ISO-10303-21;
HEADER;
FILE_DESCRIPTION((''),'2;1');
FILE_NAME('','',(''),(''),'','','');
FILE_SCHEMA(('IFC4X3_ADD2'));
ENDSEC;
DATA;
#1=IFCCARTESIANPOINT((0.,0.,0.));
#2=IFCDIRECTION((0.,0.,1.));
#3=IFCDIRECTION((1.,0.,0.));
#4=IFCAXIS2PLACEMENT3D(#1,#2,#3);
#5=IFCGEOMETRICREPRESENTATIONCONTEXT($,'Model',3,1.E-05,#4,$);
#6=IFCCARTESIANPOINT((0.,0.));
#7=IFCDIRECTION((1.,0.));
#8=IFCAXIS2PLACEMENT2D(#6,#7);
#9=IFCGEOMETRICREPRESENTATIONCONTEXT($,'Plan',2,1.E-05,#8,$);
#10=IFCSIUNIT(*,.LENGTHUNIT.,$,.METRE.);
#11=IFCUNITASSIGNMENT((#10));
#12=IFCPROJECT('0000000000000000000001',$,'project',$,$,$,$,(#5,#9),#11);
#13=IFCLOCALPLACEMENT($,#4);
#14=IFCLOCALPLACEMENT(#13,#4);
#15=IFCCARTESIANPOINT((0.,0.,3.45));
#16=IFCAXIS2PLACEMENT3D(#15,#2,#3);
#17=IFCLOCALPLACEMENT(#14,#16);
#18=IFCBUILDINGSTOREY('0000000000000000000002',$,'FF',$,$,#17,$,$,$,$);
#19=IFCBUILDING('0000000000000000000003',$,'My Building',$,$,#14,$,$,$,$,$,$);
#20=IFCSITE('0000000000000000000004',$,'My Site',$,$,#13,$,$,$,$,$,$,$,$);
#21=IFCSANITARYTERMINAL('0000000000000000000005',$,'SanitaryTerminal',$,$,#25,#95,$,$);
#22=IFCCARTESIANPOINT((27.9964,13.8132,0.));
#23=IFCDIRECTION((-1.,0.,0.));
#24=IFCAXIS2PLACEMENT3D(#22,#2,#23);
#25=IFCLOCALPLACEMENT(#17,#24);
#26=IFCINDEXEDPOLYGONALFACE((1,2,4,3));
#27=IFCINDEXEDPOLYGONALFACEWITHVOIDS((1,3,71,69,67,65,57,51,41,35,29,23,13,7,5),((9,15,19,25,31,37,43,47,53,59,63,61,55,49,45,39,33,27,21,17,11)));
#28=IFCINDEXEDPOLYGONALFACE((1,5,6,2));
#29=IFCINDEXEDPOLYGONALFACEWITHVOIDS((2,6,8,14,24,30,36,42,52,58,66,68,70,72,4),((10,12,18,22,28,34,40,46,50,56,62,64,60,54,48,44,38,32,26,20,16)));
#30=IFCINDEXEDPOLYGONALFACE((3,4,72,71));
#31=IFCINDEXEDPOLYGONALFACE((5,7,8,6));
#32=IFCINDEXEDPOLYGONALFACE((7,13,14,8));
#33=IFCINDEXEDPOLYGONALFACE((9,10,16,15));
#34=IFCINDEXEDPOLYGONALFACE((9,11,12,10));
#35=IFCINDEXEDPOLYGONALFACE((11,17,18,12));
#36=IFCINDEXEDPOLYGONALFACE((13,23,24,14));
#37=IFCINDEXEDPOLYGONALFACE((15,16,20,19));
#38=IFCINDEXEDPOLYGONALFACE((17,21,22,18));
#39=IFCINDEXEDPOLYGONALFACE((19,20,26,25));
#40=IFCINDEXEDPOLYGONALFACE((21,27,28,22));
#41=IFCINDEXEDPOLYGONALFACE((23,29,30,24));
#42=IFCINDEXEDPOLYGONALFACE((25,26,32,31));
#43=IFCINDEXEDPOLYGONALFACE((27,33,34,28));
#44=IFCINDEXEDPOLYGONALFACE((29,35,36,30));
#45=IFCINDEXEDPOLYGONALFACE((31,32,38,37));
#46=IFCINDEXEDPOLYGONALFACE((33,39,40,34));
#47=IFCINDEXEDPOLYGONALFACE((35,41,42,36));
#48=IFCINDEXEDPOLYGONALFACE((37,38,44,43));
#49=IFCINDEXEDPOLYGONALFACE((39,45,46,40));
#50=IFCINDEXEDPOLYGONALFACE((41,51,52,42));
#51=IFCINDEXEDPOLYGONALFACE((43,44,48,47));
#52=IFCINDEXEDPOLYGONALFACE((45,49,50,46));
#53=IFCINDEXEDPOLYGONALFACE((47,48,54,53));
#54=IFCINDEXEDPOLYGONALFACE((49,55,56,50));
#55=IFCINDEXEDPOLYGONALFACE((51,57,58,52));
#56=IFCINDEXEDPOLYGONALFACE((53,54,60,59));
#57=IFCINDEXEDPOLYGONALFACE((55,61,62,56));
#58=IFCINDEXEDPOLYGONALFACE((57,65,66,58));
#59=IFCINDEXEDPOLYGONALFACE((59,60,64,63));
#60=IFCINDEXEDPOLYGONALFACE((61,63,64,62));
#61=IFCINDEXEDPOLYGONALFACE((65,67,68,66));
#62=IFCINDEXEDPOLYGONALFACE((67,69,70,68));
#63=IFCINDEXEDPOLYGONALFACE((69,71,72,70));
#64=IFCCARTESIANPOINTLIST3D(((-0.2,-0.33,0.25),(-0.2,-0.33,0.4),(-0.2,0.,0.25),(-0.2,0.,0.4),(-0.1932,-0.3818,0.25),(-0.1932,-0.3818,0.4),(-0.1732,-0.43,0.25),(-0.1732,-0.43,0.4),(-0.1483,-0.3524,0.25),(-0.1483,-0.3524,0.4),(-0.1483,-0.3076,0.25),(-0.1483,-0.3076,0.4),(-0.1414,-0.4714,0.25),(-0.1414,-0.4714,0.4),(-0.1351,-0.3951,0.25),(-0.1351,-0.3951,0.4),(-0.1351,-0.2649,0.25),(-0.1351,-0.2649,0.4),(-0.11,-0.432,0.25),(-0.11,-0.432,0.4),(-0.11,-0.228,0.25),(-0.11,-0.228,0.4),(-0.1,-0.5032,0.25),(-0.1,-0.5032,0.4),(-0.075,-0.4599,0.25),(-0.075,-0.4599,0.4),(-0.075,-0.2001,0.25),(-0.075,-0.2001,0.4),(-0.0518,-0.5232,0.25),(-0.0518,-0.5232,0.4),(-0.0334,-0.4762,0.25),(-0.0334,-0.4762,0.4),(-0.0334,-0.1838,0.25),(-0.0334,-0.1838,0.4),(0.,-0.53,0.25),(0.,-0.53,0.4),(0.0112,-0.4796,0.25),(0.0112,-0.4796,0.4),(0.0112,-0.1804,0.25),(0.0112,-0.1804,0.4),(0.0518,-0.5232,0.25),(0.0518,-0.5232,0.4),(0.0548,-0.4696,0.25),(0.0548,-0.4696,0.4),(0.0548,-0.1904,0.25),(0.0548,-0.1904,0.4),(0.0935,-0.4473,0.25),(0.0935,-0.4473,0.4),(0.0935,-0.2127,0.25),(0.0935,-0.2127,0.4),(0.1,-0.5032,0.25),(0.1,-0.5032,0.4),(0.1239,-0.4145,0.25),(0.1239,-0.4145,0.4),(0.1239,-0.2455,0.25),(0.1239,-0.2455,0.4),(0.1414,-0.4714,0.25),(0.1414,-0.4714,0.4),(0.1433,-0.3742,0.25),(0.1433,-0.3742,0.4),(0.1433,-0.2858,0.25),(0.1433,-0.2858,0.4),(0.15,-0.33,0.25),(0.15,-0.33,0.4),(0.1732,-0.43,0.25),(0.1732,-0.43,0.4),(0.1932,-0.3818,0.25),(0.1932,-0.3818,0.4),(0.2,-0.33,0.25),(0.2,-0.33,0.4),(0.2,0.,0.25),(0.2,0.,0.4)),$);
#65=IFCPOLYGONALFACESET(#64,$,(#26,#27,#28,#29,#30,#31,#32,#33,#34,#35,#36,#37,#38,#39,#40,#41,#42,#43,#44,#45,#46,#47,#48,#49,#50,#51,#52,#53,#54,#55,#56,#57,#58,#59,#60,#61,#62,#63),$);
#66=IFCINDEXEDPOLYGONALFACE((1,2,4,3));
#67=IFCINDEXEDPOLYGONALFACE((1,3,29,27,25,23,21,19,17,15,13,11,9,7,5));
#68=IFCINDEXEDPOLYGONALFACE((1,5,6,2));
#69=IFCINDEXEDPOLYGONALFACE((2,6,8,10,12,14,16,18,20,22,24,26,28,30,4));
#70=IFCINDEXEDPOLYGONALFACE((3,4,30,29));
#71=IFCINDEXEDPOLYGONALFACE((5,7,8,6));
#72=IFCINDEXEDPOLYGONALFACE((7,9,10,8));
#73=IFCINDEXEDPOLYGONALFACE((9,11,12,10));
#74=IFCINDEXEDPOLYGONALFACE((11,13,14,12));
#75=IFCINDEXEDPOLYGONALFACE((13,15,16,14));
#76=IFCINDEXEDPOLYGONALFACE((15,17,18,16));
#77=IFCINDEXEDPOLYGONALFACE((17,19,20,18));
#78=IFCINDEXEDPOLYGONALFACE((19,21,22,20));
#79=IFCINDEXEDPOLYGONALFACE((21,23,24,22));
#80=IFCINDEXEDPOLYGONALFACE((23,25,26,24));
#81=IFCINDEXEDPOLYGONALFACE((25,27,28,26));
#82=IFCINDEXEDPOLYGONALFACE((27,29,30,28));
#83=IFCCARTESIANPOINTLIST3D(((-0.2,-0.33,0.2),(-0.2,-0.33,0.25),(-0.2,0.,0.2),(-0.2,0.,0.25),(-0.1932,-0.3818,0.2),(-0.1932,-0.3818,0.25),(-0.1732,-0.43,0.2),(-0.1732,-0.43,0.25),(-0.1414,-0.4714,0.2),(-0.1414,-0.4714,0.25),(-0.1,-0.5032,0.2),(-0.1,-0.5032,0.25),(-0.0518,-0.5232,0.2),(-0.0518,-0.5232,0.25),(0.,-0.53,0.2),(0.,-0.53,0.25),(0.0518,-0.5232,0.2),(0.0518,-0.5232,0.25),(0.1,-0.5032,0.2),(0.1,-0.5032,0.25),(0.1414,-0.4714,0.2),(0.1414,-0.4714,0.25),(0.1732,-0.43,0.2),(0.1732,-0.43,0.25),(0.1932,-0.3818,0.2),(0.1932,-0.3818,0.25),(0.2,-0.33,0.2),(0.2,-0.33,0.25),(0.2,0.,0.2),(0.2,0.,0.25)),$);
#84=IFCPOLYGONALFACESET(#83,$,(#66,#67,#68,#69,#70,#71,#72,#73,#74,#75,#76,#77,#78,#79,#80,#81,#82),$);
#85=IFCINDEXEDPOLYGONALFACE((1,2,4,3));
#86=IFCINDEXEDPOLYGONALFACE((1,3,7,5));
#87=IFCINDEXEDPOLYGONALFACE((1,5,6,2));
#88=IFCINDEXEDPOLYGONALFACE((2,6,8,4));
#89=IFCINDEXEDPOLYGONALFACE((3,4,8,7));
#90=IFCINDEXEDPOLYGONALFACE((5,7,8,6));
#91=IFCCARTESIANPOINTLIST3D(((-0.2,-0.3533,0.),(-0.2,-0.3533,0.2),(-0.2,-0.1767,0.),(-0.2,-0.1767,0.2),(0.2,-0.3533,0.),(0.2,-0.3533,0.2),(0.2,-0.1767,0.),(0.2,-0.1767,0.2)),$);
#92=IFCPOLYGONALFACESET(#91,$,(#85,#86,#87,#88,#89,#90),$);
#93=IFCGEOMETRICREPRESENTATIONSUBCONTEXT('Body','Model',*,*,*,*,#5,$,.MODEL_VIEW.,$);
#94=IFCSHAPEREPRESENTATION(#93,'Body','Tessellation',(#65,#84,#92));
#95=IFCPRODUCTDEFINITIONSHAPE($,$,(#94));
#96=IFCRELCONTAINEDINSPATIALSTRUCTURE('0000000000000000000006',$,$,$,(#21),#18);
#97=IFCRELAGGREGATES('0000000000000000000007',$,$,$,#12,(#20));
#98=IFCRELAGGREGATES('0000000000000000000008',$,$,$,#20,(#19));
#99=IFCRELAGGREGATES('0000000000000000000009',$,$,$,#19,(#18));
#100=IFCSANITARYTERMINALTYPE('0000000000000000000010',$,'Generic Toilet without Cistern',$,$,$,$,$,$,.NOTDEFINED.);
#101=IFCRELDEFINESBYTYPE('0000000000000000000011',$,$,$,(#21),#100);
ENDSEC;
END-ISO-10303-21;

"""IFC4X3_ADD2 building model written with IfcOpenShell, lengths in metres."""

from ifc_helpers import new_model, entity, si_unit, frame, frame_2d, origin_with_axes, origin_2d_with_axis, place, context, subcontext, project, spatial, line, arc, indexed_curve, circle_curve, outline, extrude, shape, source, transform, mapped, type_object, type_shapes, element, save


model = new_model("IFC4X3_ADD2")

# Units and contexts
model_context = context("Model", 3, precision=1e-05, world=origin_with_axes())
plan_context = context("Plan", 2, precision=1e-05, world=origin_2d_with_axis())
body_context_1 = subcontext(model_context, "Body", "Model", "MODEL_VIEW")
body_context_2 = subcontext(plan_context, "Body", "Plan", "PLAN_VIEW")
ifc_project = project(units=[si_unit("LENGTHUNIT", "METRE")], contexts=[model_context, plan_context])

# Site, building, storey
site_placement = place(None, origin_with_axes())
site = spatial("IfcSite", under=ifc_project, at=site_placement, Name="My Site")
building_placement = place(site_placement, origin_with_axes())
building = spatial("IfcBuilding", under=site, at=building_placement, Name="My Building")
storey_placement = place(building_placement, frame((0.0, 0.0, 3.45), z_axis=(0.0, 0.0, 1.0), x_axis=(1.0, 0.0, 0.0)))
storey = spatial("IfcBuildingStorey", under=building, at=storey_placement, Name="FF")

# Sanitary terminal
sanitary_terminal_type_1 = type_object("IfcSanitaryTerminalType", Name="Generic Toilet without Cistern", PredefinedType="NOTDEFINED")
shared_shape_1 = source(origin_with_axes(), body_context_1, "Body", "SweptSolid", [
    extrude(outline(indexed_curve([(-0.2, 0.0), (0.2, 0.0), (0.2, -0.33), (0.1414, -0.4714), (0.0, -0.53), (-0.1414, -0.4714), (-0.2, -0.33)], segments=[line(1, 2), line(2, 3), arc(3, 4, 5), arc(5, 6, 7), line(7, 1)]), holes=[circle_curve(frame_2d((0.0, -0.33)), 0.15)]), frame((0.0, 0.0, 0.25), z_axis=(0.0, 0.0, 1.0), x_axis=(1.0, 0.0, 0.0)), (0.0, 0.0, 1.0), 0.15),
    extrude(outline(indexed_curve([(-0.2, 0.0), (0.2, 0.0), (0.2, -0.33), (0.1414, -0.4714), (0.0, -0.53), (-0.1414, -0.4714), (-0.2, -0.33)], segments=[line(1, 2), line(2, 3), arc(3, 4, 5), arc(5, 6, 7), line(7, 1)])), frame((0.0, 0.0, 0.2), z_axis=(0.0, 0.0, 1.0), x_axis=(1.0, 0.0, 0.0)), (0.0, 0.0, 1.0), 0.05),
    extrude(outline(indexed_curve([(-0.2, -0.1767), (0.2, -0.1767), (0.2, -0.3533), (-0.2, -0.3533)], segments=[line(1, 2, 3, 4, 1)])), origin_with_axes(), (0.0, 0.0, 1.0), 0.2),
])
shared_shape_2 = source(origin_with_axes(), body_context_2, "Body", "Annotation2D", [
    entity("IfcGeometricCurveSet", [entity("IfcIndexedPolyCurve", entity("IfcCartesianPointList2D", [[-0.1068, -0.124], [-0.0957, -0.1129], [-0.0804, -0.1088], [0.0804, -0.1088], [0.0957, -0.1129], [0.1068, -0.124], [0.1109, -0.1393], [0.1109, -0.3476], [0.1025, -0.3926], [0.0784, -0.4308], [0.0424, -0.4563], [0.0, -0.4652], [-0.0424, -0.4563], [-0.0784, -0.4308], [-0.1025, -0.3926], [-0.1109, -0.3476], [-0.1109, -0.1393]]), [entity("IfcLineIndex", [1, 2, 3, 4, 5, 6, 7, 8, 9, 10, 11, 12, 13, 14, 15, 16, 17, 1])]), entity("IfcIndexedPolyCurve", entity("IfcCartesianPointList2D", [[-0.1962, -0.2314], [-0.1848, -0.301], [-0.1764, -0.3339], [-0.1663, -0.3651], [-0.1546, -0.3944], [-0.1414, -0.4213], [-0.1269, -0.4458], [-0.1111, -0.4675], [-0.0943, -0.4862], [-0.0765, -0.5018], [-0.0581, -0.514], [-0.039, -0.5229], [-0.0196, -0.5282], [0.0, -0.53], [0.0196, -0.5282], [0.039, -0.5229], [0.0581, -0.514], [0.0765, -0.5018], [0.0943, -0.4862], [0.1111, -0.4675], [0.1269, -0.4458], [0.1414, -0.4213], [0.1546, -0.3944], [0.1663, -0.3651], [0.1764, -0.3339], [0.1848, -0.301], [0.1962, -0.2314], [0.2, -0.159], [0.1872, 0.0], [-0.1872, 0.0], [-0.2, -0.159]]), [entity("IfcLineIndex", [1, 2, 3, 4, 5, 6, 7, 8, 9, 10, 11, 12, 13, 14, 15, 16, 17, 18, 19, 20, 21, 22, 23, 24, 25, 26, 27, 28, 29, 30, 31, 1])])]),
])
type_shapes(sanitary_terminal_type_1, [shared_shape_1, shared_shape_2])
sanitary_terminal_1_placement = place(storey_placement, frame((27.9964, 13.8132, 0.0), z_axis=(0.0, 0.0, 1.0), x_axis=(-1.0, 0.0, 0.0)))
element("IfcSanitaryTerminal", 1, at=sanitary_terminal_1_placement, inside=storey, type_object=sanitary_terminal_type_1, Name="SanitaryTerminal", shapes=[
    shape(body_context_1, "Body", "MappedRepresentation", [mapped(shared_shape_1, transform((0.0, 0.0, 0.0), x_axis=(1.0, 0.0, 0.0), y_axis=(0.0, 1.0, 0.0), z_axis=(0.0, 0.0, 1.0), scale=1.0))]),
    shape(body_context_2, "Body", "MappedRepresentation", [mapped(shared_shape_2, transform((0.0, 0.0, 0.0), x_axis=(1.0, 0.0, 0.0), y_axis=(0.0, 1.0, 0.0), z_axis=(0.0, 0.0, 1.0), scale=1.0))]),
])

save(model, "model.ifc")
